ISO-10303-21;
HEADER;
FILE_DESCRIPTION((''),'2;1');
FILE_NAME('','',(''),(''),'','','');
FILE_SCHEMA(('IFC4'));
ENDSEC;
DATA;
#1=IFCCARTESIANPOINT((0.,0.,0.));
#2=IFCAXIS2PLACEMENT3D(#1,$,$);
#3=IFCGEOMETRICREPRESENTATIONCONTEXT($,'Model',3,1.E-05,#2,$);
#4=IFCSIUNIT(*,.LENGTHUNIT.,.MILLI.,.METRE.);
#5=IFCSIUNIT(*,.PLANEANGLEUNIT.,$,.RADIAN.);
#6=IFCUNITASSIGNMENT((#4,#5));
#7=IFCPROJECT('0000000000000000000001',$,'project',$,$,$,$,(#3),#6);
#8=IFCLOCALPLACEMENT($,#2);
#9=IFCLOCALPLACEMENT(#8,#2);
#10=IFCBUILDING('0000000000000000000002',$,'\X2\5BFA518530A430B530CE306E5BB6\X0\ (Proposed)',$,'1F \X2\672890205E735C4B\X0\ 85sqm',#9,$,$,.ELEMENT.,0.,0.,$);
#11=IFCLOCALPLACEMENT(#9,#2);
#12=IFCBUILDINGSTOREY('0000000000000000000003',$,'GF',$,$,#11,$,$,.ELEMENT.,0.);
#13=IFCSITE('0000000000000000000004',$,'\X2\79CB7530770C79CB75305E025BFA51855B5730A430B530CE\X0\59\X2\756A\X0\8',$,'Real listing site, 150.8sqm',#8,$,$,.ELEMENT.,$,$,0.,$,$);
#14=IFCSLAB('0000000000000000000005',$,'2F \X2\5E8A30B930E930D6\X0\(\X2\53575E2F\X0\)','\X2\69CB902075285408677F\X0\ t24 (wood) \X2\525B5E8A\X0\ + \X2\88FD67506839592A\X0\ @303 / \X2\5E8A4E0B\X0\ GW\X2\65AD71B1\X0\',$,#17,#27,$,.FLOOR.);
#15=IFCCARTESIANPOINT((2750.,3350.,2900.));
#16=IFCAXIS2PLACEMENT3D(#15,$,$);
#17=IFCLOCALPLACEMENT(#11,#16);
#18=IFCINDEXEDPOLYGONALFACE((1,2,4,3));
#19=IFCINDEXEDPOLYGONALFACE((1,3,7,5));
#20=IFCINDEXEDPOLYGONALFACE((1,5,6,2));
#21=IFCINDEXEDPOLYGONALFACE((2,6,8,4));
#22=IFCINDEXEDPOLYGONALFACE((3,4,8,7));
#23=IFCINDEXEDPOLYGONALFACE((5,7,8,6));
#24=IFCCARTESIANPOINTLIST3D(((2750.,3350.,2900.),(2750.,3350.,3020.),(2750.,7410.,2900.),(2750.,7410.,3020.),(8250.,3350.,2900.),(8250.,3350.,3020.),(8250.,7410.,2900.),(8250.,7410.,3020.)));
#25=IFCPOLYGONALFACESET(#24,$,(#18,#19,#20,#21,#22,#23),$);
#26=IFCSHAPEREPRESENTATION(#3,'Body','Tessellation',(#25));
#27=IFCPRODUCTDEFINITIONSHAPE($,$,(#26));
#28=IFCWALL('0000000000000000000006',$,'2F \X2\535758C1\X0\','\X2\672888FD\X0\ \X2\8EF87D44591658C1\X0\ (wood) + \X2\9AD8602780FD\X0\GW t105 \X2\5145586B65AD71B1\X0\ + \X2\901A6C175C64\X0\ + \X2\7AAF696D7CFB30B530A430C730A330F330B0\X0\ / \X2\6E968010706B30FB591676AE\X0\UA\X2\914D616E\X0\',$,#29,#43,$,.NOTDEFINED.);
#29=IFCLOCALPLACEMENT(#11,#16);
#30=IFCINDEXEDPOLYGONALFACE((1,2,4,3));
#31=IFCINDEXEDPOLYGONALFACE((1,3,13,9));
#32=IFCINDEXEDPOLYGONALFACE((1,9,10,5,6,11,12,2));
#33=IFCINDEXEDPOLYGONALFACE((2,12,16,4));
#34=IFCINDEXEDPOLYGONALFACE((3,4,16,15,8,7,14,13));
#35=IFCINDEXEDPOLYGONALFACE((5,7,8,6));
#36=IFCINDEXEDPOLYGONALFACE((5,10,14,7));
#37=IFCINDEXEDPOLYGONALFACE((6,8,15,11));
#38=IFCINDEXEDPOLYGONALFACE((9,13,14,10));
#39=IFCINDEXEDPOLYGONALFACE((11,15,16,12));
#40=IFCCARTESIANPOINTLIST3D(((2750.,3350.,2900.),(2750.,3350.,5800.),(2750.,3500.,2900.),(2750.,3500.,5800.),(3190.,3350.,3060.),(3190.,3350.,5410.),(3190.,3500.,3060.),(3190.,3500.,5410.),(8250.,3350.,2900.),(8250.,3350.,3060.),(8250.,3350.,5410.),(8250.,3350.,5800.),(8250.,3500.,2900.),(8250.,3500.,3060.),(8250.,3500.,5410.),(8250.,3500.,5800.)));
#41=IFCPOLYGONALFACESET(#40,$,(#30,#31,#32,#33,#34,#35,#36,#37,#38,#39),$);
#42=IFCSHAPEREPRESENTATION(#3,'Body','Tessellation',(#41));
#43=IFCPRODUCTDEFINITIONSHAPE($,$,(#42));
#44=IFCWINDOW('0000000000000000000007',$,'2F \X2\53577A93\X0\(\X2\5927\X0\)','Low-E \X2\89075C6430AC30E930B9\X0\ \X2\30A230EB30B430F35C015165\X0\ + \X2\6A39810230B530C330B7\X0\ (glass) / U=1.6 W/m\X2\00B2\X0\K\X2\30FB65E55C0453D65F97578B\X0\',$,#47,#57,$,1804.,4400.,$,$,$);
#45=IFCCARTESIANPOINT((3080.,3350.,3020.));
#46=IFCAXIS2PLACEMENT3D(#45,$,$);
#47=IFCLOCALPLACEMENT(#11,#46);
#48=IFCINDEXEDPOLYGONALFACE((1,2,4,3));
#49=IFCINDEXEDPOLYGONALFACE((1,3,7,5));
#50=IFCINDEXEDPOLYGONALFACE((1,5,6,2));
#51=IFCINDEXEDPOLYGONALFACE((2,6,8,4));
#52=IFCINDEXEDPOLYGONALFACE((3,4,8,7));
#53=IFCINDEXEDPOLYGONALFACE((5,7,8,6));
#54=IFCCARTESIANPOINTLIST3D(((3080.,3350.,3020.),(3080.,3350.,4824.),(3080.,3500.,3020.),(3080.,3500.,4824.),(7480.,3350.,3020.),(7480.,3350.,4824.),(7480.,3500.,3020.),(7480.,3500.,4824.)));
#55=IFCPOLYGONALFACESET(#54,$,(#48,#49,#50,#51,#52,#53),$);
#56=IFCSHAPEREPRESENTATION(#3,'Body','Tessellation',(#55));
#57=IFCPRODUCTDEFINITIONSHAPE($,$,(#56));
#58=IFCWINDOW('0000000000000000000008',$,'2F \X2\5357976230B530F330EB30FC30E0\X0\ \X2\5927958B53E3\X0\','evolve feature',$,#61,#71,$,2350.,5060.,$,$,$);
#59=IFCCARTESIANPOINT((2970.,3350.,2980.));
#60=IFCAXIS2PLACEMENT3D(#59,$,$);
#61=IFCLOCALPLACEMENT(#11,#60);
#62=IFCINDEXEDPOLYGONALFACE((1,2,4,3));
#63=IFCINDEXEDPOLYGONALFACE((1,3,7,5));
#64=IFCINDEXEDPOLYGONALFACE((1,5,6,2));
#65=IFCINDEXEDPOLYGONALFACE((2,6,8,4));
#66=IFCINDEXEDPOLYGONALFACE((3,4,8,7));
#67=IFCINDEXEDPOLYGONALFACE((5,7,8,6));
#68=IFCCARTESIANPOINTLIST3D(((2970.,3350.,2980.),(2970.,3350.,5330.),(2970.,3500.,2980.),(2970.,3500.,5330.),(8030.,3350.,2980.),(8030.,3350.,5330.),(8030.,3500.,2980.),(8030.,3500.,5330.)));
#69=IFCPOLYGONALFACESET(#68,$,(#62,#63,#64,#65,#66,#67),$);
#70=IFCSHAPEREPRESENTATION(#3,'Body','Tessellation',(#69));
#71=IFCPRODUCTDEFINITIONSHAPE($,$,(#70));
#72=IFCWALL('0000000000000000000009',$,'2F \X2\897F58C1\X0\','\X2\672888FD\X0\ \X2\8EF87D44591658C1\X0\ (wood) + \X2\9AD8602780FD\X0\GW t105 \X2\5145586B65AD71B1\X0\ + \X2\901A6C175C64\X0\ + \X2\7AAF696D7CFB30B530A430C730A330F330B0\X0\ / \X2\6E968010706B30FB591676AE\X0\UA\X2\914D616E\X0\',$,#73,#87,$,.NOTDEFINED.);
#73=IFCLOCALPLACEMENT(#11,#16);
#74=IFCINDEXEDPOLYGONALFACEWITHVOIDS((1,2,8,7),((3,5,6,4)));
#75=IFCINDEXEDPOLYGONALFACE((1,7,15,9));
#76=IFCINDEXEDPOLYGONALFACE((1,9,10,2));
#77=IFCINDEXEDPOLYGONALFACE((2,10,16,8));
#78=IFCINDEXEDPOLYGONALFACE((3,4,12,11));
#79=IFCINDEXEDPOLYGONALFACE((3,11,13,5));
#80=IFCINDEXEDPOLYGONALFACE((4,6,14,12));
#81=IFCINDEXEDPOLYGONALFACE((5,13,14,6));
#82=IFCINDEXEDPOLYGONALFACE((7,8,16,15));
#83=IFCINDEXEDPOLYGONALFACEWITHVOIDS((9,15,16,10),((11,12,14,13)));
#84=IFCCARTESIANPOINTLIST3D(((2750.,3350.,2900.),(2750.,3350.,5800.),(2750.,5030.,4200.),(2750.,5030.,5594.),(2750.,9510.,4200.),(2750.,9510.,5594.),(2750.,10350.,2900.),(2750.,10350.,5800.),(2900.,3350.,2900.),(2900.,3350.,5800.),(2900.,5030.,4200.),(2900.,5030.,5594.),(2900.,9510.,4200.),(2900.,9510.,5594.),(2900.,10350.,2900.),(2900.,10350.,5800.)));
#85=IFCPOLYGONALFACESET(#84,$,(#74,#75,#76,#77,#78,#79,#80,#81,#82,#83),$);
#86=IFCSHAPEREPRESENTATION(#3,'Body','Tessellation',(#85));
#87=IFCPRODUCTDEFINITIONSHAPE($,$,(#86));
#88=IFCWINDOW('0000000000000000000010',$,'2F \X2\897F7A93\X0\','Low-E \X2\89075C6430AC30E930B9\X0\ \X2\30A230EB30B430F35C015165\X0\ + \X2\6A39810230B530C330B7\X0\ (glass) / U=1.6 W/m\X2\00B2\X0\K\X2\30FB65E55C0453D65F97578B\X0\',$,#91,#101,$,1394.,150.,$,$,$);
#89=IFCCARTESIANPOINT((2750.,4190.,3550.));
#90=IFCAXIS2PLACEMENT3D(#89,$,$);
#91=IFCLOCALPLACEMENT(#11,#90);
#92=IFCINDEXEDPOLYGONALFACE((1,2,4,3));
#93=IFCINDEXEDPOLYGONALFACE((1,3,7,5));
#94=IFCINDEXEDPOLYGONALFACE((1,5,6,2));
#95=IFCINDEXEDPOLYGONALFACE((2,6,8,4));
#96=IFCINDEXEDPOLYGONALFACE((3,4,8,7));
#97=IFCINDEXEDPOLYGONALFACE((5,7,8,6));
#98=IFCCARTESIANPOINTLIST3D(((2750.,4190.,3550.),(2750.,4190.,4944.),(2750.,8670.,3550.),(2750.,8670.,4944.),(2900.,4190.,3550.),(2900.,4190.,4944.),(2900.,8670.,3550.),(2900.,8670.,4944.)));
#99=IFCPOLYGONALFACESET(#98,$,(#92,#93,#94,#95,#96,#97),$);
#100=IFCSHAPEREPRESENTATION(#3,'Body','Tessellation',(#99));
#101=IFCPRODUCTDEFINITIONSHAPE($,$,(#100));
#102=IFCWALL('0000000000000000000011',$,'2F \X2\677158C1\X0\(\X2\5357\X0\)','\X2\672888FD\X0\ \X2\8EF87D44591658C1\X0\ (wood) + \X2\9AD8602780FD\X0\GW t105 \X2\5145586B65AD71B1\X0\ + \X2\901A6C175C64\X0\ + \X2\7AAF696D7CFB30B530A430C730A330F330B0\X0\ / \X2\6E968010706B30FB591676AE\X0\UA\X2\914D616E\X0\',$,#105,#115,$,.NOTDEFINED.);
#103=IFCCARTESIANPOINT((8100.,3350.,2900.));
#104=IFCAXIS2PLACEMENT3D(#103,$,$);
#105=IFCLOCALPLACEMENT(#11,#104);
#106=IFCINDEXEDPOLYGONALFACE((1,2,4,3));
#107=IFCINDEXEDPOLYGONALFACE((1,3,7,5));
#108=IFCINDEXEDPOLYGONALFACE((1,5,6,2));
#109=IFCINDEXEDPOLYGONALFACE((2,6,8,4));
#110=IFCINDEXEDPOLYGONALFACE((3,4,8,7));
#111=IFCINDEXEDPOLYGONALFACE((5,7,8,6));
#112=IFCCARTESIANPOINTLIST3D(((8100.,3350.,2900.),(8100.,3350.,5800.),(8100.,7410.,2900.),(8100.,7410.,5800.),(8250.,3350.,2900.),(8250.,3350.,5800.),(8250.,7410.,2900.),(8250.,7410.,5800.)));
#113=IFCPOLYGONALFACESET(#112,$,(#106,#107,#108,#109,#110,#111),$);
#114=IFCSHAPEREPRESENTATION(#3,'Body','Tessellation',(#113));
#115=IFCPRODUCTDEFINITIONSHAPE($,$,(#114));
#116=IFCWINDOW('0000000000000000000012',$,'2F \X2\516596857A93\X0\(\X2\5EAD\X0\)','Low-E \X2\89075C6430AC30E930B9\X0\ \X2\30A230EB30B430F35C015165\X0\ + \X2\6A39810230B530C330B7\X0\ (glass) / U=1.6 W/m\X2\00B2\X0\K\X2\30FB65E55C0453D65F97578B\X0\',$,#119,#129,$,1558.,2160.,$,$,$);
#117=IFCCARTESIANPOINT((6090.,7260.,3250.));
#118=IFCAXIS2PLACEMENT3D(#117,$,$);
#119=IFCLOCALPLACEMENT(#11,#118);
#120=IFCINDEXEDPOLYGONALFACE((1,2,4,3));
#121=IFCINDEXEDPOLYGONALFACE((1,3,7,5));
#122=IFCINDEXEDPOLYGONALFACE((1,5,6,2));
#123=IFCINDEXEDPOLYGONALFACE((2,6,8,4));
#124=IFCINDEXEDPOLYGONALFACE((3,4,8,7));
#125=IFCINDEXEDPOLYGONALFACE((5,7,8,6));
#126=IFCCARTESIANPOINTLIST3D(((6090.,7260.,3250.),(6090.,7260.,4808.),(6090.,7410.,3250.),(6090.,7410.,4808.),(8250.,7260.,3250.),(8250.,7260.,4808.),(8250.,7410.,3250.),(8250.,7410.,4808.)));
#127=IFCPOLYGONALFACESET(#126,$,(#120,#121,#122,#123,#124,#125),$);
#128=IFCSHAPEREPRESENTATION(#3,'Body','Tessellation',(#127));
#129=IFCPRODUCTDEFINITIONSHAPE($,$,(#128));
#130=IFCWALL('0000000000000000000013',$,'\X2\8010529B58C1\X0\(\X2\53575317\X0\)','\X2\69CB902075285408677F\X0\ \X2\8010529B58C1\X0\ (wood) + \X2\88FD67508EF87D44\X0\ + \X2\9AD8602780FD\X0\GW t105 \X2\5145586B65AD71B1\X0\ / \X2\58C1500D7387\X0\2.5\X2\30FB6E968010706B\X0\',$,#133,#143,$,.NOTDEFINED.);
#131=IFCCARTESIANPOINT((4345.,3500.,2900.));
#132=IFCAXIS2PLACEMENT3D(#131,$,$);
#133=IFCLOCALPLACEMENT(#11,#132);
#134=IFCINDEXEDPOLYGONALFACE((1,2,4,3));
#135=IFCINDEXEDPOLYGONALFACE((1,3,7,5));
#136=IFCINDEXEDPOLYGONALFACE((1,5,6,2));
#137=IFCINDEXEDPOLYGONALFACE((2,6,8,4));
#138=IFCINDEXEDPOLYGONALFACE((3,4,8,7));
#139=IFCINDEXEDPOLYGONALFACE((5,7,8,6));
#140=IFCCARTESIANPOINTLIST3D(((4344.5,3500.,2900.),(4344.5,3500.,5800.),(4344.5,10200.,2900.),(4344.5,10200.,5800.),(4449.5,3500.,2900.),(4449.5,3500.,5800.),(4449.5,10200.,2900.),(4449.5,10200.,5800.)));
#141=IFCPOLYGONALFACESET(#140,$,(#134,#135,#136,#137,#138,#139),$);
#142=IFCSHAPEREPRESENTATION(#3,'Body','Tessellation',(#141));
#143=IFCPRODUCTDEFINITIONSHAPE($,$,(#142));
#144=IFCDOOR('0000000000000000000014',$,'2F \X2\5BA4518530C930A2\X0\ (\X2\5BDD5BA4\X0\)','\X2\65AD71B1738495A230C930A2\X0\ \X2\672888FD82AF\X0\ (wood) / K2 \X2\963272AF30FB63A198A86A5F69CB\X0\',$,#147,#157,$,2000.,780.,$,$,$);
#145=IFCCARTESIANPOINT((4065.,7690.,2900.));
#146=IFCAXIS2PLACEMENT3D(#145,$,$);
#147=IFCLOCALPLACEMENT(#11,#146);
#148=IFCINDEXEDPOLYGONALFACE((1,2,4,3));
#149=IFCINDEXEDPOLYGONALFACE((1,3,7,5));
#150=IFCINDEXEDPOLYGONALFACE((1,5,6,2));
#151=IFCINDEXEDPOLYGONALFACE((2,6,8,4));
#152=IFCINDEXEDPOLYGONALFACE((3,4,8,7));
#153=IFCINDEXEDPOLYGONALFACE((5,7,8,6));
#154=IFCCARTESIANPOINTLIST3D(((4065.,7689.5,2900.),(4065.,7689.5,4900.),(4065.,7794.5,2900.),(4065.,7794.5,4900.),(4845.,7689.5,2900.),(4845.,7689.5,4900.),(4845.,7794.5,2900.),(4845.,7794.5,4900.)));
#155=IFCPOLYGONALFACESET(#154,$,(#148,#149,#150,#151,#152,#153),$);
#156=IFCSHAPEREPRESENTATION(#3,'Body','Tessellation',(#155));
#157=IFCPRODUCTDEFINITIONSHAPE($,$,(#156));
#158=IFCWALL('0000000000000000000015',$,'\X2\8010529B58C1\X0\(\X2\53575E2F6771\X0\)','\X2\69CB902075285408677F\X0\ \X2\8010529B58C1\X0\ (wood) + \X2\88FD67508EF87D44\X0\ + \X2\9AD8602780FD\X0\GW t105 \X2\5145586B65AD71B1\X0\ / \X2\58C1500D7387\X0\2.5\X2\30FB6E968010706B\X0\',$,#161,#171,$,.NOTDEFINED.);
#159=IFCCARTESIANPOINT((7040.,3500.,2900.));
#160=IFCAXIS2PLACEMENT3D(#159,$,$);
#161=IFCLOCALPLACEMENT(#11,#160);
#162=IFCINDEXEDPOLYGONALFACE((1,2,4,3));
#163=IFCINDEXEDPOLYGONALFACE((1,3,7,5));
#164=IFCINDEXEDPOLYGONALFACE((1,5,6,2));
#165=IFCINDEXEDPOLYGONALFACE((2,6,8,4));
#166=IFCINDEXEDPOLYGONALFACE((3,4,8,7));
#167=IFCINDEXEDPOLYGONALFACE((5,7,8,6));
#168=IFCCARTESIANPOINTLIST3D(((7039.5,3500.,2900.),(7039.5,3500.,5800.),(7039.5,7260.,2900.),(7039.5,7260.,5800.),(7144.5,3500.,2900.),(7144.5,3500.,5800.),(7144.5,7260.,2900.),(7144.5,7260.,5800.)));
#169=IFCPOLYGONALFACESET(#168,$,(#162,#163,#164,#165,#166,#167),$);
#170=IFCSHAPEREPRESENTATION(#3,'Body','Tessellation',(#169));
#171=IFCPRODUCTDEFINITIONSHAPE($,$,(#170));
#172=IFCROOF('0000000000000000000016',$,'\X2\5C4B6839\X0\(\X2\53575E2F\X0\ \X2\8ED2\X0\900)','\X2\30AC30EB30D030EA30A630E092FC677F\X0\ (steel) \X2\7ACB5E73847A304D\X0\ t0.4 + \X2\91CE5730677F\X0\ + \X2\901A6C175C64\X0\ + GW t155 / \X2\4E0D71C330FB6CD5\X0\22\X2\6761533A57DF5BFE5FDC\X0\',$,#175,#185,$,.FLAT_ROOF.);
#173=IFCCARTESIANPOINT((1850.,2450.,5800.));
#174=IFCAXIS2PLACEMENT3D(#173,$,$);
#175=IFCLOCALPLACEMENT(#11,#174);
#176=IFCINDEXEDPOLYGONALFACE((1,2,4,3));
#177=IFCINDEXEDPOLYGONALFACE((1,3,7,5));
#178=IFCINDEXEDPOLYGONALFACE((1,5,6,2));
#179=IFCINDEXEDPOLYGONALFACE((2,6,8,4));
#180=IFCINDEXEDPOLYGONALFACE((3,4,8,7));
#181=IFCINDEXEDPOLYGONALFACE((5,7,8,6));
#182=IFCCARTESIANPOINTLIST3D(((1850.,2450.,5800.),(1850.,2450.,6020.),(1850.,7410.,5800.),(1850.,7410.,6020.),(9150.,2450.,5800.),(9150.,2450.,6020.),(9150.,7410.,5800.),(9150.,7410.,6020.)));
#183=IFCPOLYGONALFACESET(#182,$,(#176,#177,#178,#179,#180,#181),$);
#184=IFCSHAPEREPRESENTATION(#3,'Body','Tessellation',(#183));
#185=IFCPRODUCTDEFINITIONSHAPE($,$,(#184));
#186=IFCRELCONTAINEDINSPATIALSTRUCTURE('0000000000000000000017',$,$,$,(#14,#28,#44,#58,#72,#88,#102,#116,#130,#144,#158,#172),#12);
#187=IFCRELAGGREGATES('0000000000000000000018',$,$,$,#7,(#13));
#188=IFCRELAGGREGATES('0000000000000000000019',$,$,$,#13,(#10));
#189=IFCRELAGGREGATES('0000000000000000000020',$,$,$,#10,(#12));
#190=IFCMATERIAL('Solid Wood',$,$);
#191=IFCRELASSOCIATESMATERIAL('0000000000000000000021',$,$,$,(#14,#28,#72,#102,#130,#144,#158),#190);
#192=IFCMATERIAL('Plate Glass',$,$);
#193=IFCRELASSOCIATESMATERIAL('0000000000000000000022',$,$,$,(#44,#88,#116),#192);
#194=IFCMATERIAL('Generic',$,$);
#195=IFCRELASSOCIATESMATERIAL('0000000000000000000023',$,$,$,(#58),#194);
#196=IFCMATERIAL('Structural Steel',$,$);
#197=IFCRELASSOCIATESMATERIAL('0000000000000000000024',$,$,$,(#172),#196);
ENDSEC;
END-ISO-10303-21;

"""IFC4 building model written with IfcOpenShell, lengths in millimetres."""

from ifc_helpers import new_model, si_unit, frame, frame_2d, origin, place, context, project, spatial, rectangle, extrude, material, element, fill, save


model = new_model("IFC4")

# Units and contexts
model_context = context("Model", 3, precision=1e-05, world=origin())
ifc_project = project(units=[si_unit("LENGTHUNIT", "METRE", prefix="MILLI"), si_unit("PLANEANGLEUNIT", "RADIAN")], contexts=[model_context])

# Site, building, storey
site_placement = place(None, origin())
site = spatial("IfcSite", under=ifc_project, at=site_placement, Name="秋田県秋田市寺内字イサノ59番8", ObjectType="Real listing site, 150.8sqm", CompositionType="ELEMENT", RefElevation=0.0)
building_placement = place(site_placement, origin())
building = spatial("IfcBuilding", under=site, at=building_placement, Name="寺内イサノの家 (Proposed)", ObjectType="1F 木造平屋 85sqm", CompositionType="ELEMENT", ElevationOfRefHeight=0.0, ElevationOfTerrain=0.0)
storey_placement = place(building_placement, origin())
storey = spatial("IfcBuildingStorey", under=building, at=storey_placement, Name="GF", CompositionType="ELEMENT", Elevation=0.0)

# Slab
ifc_material_1 = material(Name="Solid Wood")
slab_placement = place(storey_placement, frame((2750.0, 3350.0, 2900.0)))
element("IfcSlab", 1, at=slab_placement, inside=storey, material=ifc_material_1, Name="2F 床スラブ(南帯)", Description="構造用合板 t24 (wood) 剛床 + 製材根太 @303 / 床下 GW断熱", PredefinedType="FLOOR", context=model_context, shape_type="SweptSolid", body=[
    extrude(rectangle(XDim=5500.0, YDim=4060.0, at=frame_2d((2750.0, 2030.0))), frame((2750.0, 3350.0, 2900.0)), (0.0, 0.0, 1.0), 120.0),
])

# Wall, openings, windows
wall_1_placement = place(storey_placement, frame((2750.0, 3350.0, 2900.0)))
wall_1 = element("IfcWall", 2, at=wall_1_placement, inside=storey, material=ifc_material_1, Name="2F 南壁", Description="木製 軸組外壁 (wood) + 高性能GW t105 充填断熱 + 通気層 + 窯業系サイディング / 準耐火・外皮UA配慮", PredefinedType="NOTDEFINED", context=model_context, shape_type="SweptSolid", body=[
    extrude(rectangle(XDim=5500.0, YDim=150.0, at=frame_2d((2750.0, 75.0))), frame((2750.0, 3350.0, 2900.0)), (0.0, 0.0, 1.0), 2900.0),
])
opening_1_placement = place(storey_placement, frame((3080.0, 3350.0, 3020.0)))
opening_1 = element("IfcOpeningElement", 3, at=opening_1_placement, cuts=wall_1, PredefinedType="NOTDEFINED", context=model_context, shape_type="SweptSolid", body=[
    extrude(rectangle(XDim=4400.0, YDim=150.0, at=frame_2d((2200.0, 75.0))), frame((3080.0, 3350.0, 3020.0)), (0.0, 0.0, 1.0), 1804.0),
])
opening_2_placement = place(storey_placement, frame((2970.0, 3350.0, 2980.0)))
opening_2 = element("IfcOpeningElement", 4, at=opening_2_placement, cuts=wall_1, PredefinedType="NOTDEFINED", context=model_context, shape_type="SweptSolid", body=[
    extrude(rectangle(XDim=5060.0, YDim=150.0, at=frame_2d((2530.0, 75.0))), frame((2970.0, 3350.0, 2980.0)), (0.0, 0.0, 1.0), 2350.0),
])
ifc_material_2 = material(Name="Plate Glass")
window_1_placement = place(storey_placement, frame((3080.0, 3350.0, 3020.0)))
window_1 = element("IfcWindow", 5, at=window_1_placement, inside=storey, material=ifc_material_2, Name="2F 南窓(大)", Description="Low-E 複層ガラス アルゴン封入 + 樹脂サッシ (glass) / U=1.6 W/m²K・日射取得型", OverallHeight=1804.0, OverallWidth=4400.0, context=model_context, shape_type="SweptSolid", body=[
    extrude(rectangle(XDim=4400.0, YDim=150.0, at=frame_2d((2200.0, 75.0))), frame((3080.0, 3350.0, 3020.0)), (0.0, 0.0, 1.0), 1804.0),
])
fill(opening_1, window_1)
ifc_material_3 = material(Name="Generic")
window_2_placement = place(storey_placement, frame((2970.0, 3350.0, 2980.0)))
window_2 = element("IfcWindow", 6, at=window_2_placement, inside=storey, material=ifc_material_3, Name="2F 南面サンルーム 大開口", Description="evolve feature", OverallHeight=2350.0, OverallWidth=5060.0, context=model_context, shape_type="SweptSolid", body=[
    extrude(rectangle(XDim=5060.0, YDim=150.0, at=frame_2d((2530.0, 75.0))), frame((2970.0, 3350.0, 2980.0)), (0.0, 0.0, 1.0), 2350.0),
])
fill(opening_2, window_2)

# Walls, openings, windows
wall_2_placement = place(storey_placement, frame((2750.0, 3350.0, 2900.0)))
wall_2 = element("IfcWall", 7, at=wall_2_placement, inside=storey, material=ifc_material_1, Name="2F 西壁", Description="木製 軸組外壁 (wood) + 高性能GW t105 充填断熱 + 通気層 + 窯業系サイディング / 準耐火・外皮UA配慮", PredefinedType="NOTDEFINED", context=model_context, shape_type="SweptSolid", body=[
    extrude(rectangle(XDim=150.0, YDim=7000.0, at=frame_2d((75.0, 3500.0))), frame((2750.0, 3350.0, 2900.0)), (0.0, 0.0, 1.0), 2900.0),
])
opening_3_placement = place(storey_placement, frame((2750.0, 4190.0, 3550.0)))
opening_3 = element("IfcOpeningElement", 8, at=opening_3_placement, cuts=wall_2, PredefinedType="NOTDEFINED", context=model_context, shape_type="SweptSolid", body=[
    extrude(rectangle(XDim=150.0, YDim=4480.0, at=frame_2d((75.0, 2240.0))), frame((2750.0, 4190.0, 3550.0)), (0.0, 0.0, 1.0), 1394.0),
])
window_3_placement = place(storey_placement, frame((2750.0, 4190.0, 3550.0)))
window_3 = element("IfcWindow", 9, at=window_3_placement, inside=storey, material=ifc_material_2, Name="2F 西窓", Description="Low-E 複層ガラス アルゴン封入 + 樹脂サッシ (glass) / U=1.6 W/m²K・日射取得型", OverallHeight=1394.0, OverallWidth=150.0, context=model_context, shape_type="SweptSolid", body=[
    extrude(rectangle(XDim=150.0, YDim=4480.0, at=frame_2d((75.0, 2240.0))), frame((2750.0, 4190.0, 3550.0)), (0.0, 0.0, 1.0), 1394.0),
])
fill(opening_3, window_3)
wall_3_placement = place(storey_placement, frame((8100.0, 3350.0, 2900.0)))
wall_3 = element("IfcWall", 10, at=wall_3_placement, inside=storey, material=ifc_material_1, Name="2F 東壁(南)", Description="木製 軸組外壁 (wood) + 高性能GW t105 充填断熱 + 通気層 + 窯業系サイディング / 準耐火・外皮UA配慮", PredefinedType="NOTDEFINED", context=model_context, shape_type="SweptSolid", body=[
    extrude(rectangle(XDim=150.0, YDim=4060.0, at=frame_2d((75.0, 2030.0))), frame((8100.0, 3350.0, 2900.0)), (0.0, 0.0, 1.0), 2900.0),
])
opening_4_placement = place(storey_placement, frame((6090.0, 7260.0, 3250.0)))
opening_4 = element("IfcOpeningElement", 11, at=opening_4_placement, cuts=wall_3, PredefinedType="NOTDEFINED", context=model_context, shape_type="SweptSolid", body=[
    extrude(rectangle(XDim=2160.0, YDim=150.0, at=frame_2d((1080.0, 75.0))), frame((6090.0, 7260.0, 3250.0)), (0.0, 0.0, 1.0), 1558.0),
])
window_4_placement = place(storey_placement, frame((6090.0, 7260.0, 3250.0)))
window_4 = element("IfcWindow", 12, at=window_4_placement, inside=storey, material=ifc_material_2, Name="2F 入隅窓(庭)", Description="Low-E 複層ガラス アルゴン封入 + 樹脂サッシ (glass) / U=1.6 W/m²K・日射取得型", OverallHeight=1558.0, OverallWidth=2160.0, context=model_context, shape_type="SweptSolid", body=[
    extrude(rectangle(XDim=2160.0, YDim=150.0, at=frame_2d((1080.0, 75.0))), frame((6090.0, 7260.0, 3250.0)), (0.0, 0.0, 1.0), 1558.0),
])
fill(opening_4, window_4)

# Wall, opening, door
wall_4_placement = place(storey_placement, frame((4345.0, 3500.0, 2900.0)))
wall_4 = element("IfcWall", 13, at=wall_4_placement, inside=storey, material=ifc_material_1, Name="耐力壁(南北)", Description="構造用合板 耐力壁 (wood) + 製材軸組 + 高性能GW t105 充填断熱 / 壁倍率2.5・準耐火", PredefinedType="NOTDEFINED", context=model_context, shape_type="SweptSolid", body=[
    extrude(rectangle(XDim=105.0, YDim=6700.0, at=frame_2d((52.0, 3350.0))), frame((4345.0, 3500.0, 2900.0)), (0.0, 0.0, 1.0), 2900.0),
])
opening_5_placement = place(storey_placement, frame((4065.0, 7690.0, 2900.0)))
opening_5 = element("IfcOpeningElement", 14, at=opening_5_placement, cuts=wall_4, PredefinedType="NOTDEFINED", context=model_context, shape_type="SweptSolid", body=[
    extrude(rectangle(XDim=780.0, YDim=105.0, at=frame_2d((390.0, 52.0))), frame((4065.0, 7690.0, 2900.0)), (0.0, 0.0, 1.0), 2000.0),
])
door_placement = place(storey_placement, frame((4065.0, 7690.0, 2900.0)))
door = element("IfcDoor", 15, at=door_placement, inside=storey, material=ifc_material_1, Name="2F 室内ドア (寝室)", Description="断熱玄関ドア 木製芯 (wood) / K2 防犯・採風機構", OverallHeight=2000.0, OverallWidth=780.0, context=model_context, shape_type="SweptSolid", body=[
    extrude(rectangle(XDim=780.0, YDim=105.0, at=frame_2d((390.0, 52.0))), frame((4065.0, 7690.0, 2900.0)), (0.0, 0.0, 1.0), 2000.0),
])
fill(opening_5, door)

# Wall
wall_5_placement = place(storey_placement, frame((7040.0, 3500.0, 2900.0)))
element("IfcWall", 16, at=wall_5_placement, inside=storey, material=ifc_material_1, Name="耐力壁(南帯東)", Description="構造用合板 耐力壁 (wood) + 製材軸組 + 高性能GW t105 充填断熱 / 壁倍率2.5・準耐火", PredefinedType="NOTDEFINED", context=model_context, shape_type="SweptSolid", body=[
    extrude(rectangle(XDim=105.0, YDim=3760.0, at=frame_2d((52.0, 1880.0))), frame((7040.0, 3500.0, 2900.0)), (0.0, 0.0, 1.0), 2900.0),
])

# Roof
ifc_material_4 = material(Name="Structural Steel")
for number, where, name in (
    (17, (1850.0, 2450.0, 5800.0), "屋根(南帯 軒900)"),
):
    element("IfcRoof", number, at=place(storey_placement, frame(where)), inside=storey, material=ifc_material_4, Name=name, Description="ガルバリウム鋼板 (steel) 立平葺き t0.4 + 野地板 + 通気層 + GW t155 / 不燃・法22条区域対応", PredefinedType="FLAT_ROOF", context=model_context, shape_type="SweptSolid", body=[
        extrude(rectangle(XDim=7300.0, YDim=4960.0, at=frame_2d((3650.0, 2480.0))), frame((1850.0, 2450.0, 5800.0)), (0.0, 0.0, 1.0), 220.0),
    ])

save(model, "model.ifc")
